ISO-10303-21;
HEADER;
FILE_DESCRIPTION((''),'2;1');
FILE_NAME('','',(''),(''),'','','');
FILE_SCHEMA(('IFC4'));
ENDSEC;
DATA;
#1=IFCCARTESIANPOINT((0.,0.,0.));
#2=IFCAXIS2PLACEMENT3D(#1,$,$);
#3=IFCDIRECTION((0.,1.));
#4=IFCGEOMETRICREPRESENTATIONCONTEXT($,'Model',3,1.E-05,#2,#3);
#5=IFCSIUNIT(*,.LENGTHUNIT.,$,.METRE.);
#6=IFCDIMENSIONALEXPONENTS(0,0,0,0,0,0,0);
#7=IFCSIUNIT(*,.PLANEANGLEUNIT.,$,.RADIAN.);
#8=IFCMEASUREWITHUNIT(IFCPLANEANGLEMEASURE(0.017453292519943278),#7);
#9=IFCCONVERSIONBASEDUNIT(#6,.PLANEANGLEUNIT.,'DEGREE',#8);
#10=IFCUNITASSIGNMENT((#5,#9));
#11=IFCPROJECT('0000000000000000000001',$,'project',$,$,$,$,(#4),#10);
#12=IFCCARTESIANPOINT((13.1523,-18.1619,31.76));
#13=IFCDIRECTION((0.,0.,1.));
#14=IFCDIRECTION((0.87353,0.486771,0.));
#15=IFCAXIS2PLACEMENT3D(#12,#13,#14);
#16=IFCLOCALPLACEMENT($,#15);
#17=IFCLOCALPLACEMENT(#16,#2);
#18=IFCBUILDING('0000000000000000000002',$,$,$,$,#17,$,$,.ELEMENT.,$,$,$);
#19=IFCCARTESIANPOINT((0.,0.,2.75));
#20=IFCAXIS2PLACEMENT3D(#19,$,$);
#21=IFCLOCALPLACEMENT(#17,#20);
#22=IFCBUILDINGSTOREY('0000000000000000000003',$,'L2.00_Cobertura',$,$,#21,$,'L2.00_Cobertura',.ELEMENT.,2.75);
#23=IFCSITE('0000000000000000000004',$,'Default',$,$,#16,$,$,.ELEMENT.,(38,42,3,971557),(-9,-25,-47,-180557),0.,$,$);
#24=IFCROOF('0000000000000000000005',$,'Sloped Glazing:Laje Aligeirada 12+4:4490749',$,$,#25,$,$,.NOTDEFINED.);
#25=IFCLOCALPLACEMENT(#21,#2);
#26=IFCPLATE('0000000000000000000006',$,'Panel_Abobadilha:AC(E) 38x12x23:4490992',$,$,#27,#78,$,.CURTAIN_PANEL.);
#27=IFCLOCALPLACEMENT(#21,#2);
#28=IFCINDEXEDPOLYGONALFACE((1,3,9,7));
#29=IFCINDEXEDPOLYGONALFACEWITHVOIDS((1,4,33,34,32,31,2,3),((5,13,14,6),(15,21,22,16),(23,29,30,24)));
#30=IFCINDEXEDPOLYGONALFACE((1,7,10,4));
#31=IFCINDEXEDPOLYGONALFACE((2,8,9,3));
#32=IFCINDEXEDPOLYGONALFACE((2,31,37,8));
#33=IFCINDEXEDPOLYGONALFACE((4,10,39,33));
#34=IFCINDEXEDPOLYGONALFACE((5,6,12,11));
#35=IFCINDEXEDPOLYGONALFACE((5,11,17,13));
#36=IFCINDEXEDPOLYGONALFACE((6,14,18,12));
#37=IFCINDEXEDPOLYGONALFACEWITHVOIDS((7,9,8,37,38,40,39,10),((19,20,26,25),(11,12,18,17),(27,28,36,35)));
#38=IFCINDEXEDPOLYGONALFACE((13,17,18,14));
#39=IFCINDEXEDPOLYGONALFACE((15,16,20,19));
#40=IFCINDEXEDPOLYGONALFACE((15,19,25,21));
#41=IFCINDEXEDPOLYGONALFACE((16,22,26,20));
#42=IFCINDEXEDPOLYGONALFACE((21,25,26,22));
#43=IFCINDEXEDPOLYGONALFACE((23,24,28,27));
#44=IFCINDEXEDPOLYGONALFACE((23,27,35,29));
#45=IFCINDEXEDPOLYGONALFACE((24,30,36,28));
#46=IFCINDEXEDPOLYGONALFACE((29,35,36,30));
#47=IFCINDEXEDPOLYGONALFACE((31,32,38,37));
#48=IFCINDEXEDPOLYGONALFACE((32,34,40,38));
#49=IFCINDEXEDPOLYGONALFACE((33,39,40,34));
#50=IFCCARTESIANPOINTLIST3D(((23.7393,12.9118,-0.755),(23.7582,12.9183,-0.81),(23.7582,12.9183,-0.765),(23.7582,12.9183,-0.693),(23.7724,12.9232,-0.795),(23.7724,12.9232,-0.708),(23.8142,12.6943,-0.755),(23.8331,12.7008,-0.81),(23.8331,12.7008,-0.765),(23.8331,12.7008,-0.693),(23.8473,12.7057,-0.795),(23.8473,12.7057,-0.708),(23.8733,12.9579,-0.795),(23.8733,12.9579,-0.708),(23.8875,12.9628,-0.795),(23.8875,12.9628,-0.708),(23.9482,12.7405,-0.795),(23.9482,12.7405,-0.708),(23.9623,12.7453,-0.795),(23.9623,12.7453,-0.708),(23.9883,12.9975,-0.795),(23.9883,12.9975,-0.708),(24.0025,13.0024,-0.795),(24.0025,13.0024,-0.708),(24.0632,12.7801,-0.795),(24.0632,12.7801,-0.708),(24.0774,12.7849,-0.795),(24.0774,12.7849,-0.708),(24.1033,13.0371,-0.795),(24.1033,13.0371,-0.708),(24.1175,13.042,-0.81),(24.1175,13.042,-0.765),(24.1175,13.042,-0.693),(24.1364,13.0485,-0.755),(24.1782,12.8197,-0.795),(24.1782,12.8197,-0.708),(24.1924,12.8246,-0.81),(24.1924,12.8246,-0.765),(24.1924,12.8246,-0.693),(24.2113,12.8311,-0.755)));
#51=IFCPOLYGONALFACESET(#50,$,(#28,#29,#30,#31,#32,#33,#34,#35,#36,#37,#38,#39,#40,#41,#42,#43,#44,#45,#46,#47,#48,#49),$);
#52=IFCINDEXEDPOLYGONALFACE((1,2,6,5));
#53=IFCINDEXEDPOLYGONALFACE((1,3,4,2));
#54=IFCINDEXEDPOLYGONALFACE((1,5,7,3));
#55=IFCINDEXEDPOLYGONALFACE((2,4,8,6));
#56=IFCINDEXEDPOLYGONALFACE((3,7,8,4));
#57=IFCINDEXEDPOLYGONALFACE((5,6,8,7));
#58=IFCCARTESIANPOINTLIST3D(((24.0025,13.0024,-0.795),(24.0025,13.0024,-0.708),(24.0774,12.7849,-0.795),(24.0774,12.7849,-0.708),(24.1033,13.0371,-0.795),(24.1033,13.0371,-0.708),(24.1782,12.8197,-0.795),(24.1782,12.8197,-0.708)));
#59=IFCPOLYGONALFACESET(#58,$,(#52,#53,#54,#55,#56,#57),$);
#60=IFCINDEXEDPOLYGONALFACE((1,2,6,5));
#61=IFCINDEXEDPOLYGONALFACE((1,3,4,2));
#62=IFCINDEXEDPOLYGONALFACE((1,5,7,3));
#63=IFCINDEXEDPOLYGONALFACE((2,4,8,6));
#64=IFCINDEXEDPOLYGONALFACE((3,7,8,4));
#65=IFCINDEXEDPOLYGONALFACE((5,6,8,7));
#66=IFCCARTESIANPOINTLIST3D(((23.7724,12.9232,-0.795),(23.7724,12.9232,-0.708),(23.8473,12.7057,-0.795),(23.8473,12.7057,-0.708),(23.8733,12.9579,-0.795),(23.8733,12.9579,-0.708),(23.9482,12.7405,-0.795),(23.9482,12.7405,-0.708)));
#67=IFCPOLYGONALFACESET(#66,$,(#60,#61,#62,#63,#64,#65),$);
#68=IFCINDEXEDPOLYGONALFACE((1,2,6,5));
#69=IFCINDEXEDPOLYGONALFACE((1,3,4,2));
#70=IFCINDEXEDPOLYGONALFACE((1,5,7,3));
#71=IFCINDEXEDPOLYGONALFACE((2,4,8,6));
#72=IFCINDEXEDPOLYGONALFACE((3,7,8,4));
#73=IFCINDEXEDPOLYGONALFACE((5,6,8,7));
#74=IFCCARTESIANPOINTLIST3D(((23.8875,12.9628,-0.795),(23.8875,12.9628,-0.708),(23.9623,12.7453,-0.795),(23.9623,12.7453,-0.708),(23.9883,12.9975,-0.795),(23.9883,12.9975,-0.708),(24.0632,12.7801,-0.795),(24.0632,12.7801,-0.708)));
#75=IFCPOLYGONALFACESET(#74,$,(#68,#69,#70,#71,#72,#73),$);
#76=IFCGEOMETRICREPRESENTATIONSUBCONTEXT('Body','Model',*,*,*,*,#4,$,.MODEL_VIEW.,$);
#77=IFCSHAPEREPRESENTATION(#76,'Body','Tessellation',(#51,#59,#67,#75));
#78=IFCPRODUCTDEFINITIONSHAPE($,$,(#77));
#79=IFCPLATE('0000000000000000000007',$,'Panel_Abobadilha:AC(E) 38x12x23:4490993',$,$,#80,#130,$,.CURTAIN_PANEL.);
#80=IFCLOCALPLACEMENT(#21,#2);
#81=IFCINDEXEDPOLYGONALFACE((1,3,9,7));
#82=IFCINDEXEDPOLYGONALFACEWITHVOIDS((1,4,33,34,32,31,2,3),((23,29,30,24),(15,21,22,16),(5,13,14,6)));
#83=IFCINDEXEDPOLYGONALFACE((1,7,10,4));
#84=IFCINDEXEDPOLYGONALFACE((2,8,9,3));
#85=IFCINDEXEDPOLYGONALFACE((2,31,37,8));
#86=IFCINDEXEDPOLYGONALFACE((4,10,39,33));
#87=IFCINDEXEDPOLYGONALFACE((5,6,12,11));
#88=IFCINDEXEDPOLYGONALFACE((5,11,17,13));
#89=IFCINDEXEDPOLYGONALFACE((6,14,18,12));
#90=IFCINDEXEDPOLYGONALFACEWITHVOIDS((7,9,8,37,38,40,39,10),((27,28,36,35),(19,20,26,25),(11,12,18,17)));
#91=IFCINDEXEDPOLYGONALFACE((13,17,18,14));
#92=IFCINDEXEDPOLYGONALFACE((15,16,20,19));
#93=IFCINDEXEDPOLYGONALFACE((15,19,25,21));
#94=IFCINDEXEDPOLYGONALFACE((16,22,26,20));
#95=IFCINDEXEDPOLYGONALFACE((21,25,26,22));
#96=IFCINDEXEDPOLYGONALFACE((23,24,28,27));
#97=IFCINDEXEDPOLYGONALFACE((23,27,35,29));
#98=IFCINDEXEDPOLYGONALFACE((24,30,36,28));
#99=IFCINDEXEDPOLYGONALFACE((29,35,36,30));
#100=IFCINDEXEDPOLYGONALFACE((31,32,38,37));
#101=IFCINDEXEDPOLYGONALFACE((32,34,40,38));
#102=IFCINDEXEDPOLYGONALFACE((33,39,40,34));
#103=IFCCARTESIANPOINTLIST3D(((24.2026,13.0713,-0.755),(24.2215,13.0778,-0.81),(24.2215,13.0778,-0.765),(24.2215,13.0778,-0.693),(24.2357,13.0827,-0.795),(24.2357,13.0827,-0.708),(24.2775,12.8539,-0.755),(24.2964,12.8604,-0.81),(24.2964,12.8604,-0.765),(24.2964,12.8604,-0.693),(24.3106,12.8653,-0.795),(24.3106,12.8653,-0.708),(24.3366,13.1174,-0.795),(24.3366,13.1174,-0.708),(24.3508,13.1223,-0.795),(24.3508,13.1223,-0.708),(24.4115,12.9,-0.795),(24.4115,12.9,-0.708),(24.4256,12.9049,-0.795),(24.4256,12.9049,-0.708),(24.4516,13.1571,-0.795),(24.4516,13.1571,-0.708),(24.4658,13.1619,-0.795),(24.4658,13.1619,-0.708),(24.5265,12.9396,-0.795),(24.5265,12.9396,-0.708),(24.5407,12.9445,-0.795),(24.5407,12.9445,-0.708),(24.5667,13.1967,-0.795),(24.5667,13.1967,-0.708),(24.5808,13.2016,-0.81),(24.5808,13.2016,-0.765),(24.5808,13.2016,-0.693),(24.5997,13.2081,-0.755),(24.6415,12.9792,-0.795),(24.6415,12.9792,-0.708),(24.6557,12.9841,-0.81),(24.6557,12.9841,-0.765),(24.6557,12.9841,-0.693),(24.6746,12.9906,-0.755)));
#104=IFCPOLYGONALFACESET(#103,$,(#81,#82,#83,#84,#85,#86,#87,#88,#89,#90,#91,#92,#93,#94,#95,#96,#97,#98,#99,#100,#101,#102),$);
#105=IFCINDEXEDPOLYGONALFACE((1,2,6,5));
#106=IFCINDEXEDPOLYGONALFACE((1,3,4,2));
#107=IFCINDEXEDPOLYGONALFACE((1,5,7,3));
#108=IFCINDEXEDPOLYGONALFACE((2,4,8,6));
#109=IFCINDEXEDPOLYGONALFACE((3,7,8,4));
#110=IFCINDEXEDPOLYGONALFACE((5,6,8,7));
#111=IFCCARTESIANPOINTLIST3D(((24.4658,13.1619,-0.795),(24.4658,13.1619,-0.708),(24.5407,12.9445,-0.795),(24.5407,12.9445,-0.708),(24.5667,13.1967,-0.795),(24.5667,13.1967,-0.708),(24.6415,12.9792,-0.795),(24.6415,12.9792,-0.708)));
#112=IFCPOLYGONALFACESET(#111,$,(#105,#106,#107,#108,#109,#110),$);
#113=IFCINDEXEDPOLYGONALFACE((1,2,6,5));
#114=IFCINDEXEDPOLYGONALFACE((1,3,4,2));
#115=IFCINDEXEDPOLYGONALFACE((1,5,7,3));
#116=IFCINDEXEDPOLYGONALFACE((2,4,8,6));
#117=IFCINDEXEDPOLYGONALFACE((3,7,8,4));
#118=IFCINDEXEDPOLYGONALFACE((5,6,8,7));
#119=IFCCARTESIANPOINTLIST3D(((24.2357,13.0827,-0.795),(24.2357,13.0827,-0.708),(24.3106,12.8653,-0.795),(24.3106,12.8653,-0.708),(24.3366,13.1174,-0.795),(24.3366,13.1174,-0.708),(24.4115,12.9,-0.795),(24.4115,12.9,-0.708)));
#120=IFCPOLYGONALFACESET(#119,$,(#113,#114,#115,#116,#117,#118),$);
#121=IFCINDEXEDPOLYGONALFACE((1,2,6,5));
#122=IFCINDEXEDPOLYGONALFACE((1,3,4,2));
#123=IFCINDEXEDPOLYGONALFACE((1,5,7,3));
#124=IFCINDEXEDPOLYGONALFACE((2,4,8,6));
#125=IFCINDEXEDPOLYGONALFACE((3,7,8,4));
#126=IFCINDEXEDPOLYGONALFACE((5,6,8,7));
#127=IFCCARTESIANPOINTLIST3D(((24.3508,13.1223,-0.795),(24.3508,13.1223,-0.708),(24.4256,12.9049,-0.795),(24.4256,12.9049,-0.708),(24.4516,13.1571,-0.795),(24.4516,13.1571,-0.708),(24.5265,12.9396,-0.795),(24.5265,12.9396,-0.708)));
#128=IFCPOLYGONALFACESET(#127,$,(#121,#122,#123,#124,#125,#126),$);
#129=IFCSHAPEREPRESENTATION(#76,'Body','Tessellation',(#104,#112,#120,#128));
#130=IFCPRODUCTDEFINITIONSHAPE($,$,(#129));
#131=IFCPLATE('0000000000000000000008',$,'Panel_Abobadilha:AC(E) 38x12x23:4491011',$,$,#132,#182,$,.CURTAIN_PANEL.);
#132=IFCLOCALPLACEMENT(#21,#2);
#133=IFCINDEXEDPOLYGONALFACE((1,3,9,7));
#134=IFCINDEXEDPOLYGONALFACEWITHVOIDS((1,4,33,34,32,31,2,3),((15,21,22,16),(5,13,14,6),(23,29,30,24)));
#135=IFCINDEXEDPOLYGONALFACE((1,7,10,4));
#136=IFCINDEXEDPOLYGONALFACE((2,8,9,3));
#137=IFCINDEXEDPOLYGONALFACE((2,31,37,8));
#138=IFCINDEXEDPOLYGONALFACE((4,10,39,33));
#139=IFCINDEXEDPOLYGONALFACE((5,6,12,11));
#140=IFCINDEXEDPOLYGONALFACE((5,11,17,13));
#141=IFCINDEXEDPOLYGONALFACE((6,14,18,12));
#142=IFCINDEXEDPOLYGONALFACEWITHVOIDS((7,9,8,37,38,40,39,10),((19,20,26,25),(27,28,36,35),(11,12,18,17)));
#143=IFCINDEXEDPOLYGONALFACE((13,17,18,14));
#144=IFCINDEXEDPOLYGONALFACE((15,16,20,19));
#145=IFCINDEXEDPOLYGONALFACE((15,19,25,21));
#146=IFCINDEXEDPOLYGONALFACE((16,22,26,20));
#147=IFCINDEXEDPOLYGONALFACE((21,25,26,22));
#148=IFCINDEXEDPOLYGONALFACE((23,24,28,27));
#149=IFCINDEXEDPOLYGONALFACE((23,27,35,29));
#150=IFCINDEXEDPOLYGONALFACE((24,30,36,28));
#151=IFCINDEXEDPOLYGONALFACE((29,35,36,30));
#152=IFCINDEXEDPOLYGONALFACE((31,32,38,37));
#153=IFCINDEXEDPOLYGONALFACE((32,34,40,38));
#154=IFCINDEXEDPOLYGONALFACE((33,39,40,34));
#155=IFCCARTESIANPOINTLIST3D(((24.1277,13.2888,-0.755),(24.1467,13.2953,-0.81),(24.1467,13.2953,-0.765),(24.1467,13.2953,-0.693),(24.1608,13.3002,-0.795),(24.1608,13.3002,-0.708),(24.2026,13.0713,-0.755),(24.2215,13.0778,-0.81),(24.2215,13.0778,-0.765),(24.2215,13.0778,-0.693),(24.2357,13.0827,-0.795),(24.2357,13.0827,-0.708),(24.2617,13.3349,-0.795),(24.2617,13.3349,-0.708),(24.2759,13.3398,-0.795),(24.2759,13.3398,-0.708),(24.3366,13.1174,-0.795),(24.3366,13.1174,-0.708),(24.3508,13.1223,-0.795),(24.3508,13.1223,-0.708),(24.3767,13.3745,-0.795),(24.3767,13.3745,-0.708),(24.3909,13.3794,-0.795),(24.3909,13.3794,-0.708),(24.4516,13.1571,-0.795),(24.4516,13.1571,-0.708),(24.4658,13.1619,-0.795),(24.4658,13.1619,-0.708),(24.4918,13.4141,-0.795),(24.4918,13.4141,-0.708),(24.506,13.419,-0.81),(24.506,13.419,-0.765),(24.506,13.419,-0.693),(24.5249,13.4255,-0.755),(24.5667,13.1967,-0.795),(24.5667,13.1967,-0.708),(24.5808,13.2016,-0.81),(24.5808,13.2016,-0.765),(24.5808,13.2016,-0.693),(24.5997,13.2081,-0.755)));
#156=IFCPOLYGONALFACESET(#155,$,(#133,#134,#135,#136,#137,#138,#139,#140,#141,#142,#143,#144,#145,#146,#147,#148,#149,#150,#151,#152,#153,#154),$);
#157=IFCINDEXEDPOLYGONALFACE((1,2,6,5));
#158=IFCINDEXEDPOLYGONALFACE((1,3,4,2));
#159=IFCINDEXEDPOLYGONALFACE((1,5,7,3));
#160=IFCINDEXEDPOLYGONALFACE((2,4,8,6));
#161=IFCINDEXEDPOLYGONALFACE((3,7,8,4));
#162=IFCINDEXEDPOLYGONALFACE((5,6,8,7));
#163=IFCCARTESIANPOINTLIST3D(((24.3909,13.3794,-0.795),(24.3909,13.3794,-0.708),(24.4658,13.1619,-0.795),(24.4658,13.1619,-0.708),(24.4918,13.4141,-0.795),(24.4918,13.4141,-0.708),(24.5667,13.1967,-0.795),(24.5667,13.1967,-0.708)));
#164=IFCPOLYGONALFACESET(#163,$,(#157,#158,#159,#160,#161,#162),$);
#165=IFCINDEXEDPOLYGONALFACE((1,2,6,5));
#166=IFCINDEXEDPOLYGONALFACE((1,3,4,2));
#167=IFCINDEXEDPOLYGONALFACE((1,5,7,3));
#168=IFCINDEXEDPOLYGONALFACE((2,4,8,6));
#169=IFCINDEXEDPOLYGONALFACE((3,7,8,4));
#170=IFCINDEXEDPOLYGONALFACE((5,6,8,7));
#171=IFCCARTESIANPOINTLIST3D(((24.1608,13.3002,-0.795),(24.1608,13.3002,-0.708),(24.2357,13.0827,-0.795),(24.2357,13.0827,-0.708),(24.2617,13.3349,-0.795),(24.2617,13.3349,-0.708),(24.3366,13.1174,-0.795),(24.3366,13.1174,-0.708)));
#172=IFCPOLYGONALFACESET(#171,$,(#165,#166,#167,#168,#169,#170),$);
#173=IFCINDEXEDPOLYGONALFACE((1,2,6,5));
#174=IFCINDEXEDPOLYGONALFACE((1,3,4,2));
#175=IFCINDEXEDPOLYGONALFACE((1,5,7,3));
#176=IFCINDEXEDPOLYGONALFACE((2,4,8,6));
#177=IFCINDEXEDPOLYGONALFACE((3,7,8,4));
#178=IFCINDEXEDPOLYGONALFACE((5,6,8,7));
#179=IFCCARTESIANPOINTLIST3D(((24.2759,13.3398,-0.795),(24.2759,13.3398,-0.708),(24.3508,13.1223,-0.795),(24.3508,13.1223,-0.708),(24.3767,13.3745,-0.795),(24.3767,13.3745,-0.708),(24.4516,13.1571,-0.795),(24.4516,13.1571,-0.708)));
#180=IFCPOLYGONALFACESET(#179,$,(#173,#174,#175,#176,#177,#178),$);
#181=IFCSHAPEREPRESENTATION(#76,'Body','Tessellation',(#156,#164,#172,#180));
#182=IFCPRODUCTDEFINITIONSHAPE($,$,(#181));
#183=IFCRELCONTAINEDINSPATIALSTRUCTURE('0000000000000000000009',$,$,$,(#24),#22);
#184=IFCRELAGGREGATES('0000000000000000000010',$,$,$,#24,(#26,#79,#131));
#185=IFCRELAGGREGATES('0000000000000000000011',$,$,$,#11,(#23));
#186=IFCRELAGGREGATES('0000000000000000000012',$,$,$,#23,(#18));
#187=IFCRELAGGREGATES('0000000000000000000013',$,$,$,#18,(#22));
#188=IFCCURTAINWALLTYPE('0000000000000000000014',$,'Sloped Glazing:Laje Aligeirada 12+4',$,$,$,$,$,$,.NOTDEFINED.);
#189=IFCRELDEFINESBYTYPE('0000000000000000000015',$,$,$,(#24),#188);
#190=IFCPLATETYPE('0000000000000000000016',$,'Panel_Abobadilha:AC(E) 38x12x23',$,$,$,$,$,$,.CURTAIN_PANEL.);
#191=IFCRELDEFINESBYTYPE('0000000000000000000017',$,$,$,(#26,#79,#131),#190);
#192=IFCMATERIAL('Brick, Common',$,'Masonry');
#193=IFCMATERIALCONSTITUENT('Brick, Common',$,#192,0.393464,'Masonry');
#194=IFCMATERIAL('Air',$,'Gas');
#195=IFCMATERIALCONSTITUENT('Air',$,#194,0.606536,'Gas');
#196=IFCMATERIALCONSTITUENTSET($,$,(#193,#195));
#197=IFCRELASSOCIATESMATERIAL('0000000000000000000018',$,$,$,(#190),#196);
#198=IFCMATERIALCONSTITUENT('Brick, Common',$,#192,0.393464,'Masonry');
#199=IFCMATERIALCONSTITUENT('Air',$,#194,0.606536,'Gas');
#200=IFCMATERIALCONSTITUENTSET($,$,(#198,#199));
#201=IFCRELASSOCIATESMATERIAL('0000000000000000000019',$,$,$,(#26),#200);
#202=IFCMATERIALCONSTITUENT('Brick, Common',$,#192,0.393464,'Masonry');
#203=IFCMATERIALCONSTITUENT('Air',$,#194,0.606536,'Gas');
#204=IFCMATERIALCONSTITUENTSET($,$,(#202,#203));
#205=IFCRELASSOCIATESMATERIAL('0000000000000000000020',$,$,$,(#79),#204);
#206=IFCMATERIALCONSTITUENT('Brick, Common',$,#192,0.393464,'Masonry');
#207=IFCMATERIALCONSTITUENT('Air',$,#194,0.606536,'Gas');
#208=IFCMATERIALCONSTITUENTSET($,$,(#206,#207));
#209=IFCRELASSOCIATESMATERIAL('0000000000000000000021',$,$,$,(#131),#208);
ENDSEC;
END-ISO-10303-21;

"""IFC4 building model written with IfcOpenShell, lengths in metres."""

from ifc_helpers import new_model, entity, si_unit, converted_unit, direction, frame, origin, place, context, subcontext, project, spatial, indexed_curve, outline, extrude, source, transform, mapped, material, constituent, constituent_set, type_object, type_shapes, element, aggregate, save


model = new_model("IFC4")

# Units and contexts
model_context = context("Model", 3, precision=1e-05, world=origin(), true_north=direction((0.0, 1.0)))
body_context = subcontext(model_context, "Body", "Model", "MODEL_VIEW")
ifc_project = project(units=[si_unit("LENGTHUNIT", "METRE"), converted_unit("PLANEANGLEUNIT", "DEGREE", entity("IfcPlaneAngleMeasure", 0.017453292519943278), si_unit("PLANEANGLEUNIT", "RADIAN"), dimensions=[0, 0, 0, 0, 0, 0, 0])], contexts=[model_context])

# Site, building, storey
site_placement = place(None, frame((13.1523, -18.1619, 31.76), z_axis=(0.0, 0.0, 1.0), x_axis=(0.87353, 0.486771, 0.0)))
site = spatial("IfcSite", under=ifc_project, at=site_placement, Name="Default", CompositionType="ELEMENT", RefLatitude=(38, 42, 3, 971557), RefLongitude=(-9, -25, -47, -180557), RefElevation=0.0)
building_placement = place(site_placement, origin())
building = spatial("IfcBuilding", under=site, at=building_placement, CompositionType="ELEMENT")
storey_placement = place(building_placement, frame((0.0, 0.0, 2.75)))
storey = spatial("IfcBuildingStorey", under=building, at=storey_placement, Name="L2.00_Cobertura", LongName="L2.00_Cobertura", CompositionType="ELEMENT", Elevation=2.75)

# Roof, plates
curtain_wall_type = type_object("IfcCurtainWallType", Name="Sloped Glazing:Laje Aligeirada 12+4", PredefinedType="NOTDEFINED")
roof_placement = place(storey_placement, frame((0.0, 0.0, -2.75)))
roof = element("IfcRoof", 1, at=roof_placement, inside=storey, type_object=curtain_wall_type, Name="Sloped Glazing:Laje Aligeirada 12+4:4490749", PredefinedType="NOTDEFINED")
ifc_material_1 = material(Name="Brick, Common", Category="Masonry")
ifc_material_2 = material(Name="Air", Category="Gas")
ifc_constituent_1 = constituent(ifc_material_1, Name="Brick, Common", Category="Masonry", fraction=0.393464)
ifc_constituent_2 = constituent(ifc_material_2, Name="Air", Category="Gas", fraction=0.606536)
ifc_constituent_set_1 = constituent_set(constituents=[ifc_constituent_1, ifc_constituent_2])
plate_type = type_object("IfcPlateType", Name="Panel_Abobadilha:AC(E) 38x12x23", PredefinedType="CURTAIN_PANEL", material=ifc_constituent_set_1)
shared_shape_1 = source(origin(), body_context, "Body", "SweptSolid", [
    extrude(outline(indexed_curve([(-0.19, -0.0543), (0.19, -0.0543), (0.19, -0.0093), (0.21, 0.0007), (0.19, 0.0628), (-0.19, 0.0628), (-0.21, 0.0007), (-0.19, -0.0093), (-0.19, -0.0543)], self_intersect=False), holes=[indexed_curve([(-0.0683, 0.0477), (-0.0683, -0.0393), (-0.175, -0.0393), (-0.175, 0.0477), (-0.0683, 0.0477)], self_intersect=False), indexed_curve([(0.0533, 0.0477), (0.0533, -0.0393), (-0.0533, -0.0393), (-0.0533, 0.0477), (0.0533, 0.0477)], self_intersect=False), indexed_curve([(0.175, 0.0477), (0.175, -0.0393), (0.0683, -0.0393), (0.0683, 0.0477), (0.175, 0.0477)], self_intersect=False)]), frame((0.0, 0.0543, 0.0)), (0.0, 0.0, 1.0), 0.23),
    extrude(outline(indexed_curve([(-0.0533, -0.0435), (0.0533, -0.0435), (0.0533, 0.0435), (-0.0533, 0.0435), (-0.0533, -0.0435)], self_intersect=False)), frame((0.1217, 0.0585, 0.0), z_axis=(0.0, 0.0, 1.0), x_axis=(-1.0, 0.0, 0.0)), (0.0, 0.0, 1.0), 0.23),
    extrude(outline(indexed_curve([(-0.0533, -0.0435), (0.0533, -0.0435), (0.0533, 0.0435), (-0.0533, 0.0435), (-0.0533, -0.0435)], self_intersect=False)), frame((-0.1217, 0.0585, 0.0), z_axis=(0.0, 0.0, 1.0), x_axis=(-1.0, 0.0, 0.0)), (0.0, 0.0, 1.0), 0.23),
    extrude(outline(indexed_curve([(-0.0533, -0.0435), (0.0533, -0.0435), (0.0533, 0.0435), (-0.0533, 0.0435), (-0.0533, -0.0435)], self_intersect=False)), frame((0.0, 0.0585, 0.0), z_axis=(0.0, 0.0, 1.0), x_axis=(-1.0, 0.0, 0.0)), (0.0, 0.0, 1.0), 0.23),
])
type_shapes(plate_type, [shared_shape_1])
ifc_constituent_3 = constituent(ifc_material_1, Name="Brick, Common", Category="Masonry", fraction=0.393464)
ifc_constituent_4 = constituent(ifc_material_2, Name="Air", Category="Gas", fraction=0.606536)
ifc_constituent_set_2 = constituent_set(constituents=[ifc_constituent_3, ifc_constituent_4])
plate_1_placement = place(roof_placement, frame((23.9379, 12.9802, 1.94), z_axis=(0.325568, -0.945519, 0.0), x_axis=(0.945519, 0.325568, 0.0)))
plate_1 = element("IfcPlate", 2, at=plate_1_placement, type_object=plate_type, material=ifc_constituent_set_2, Name="Panel_Abobadilha:AC(E) 38x12x23:4490992", PredefinedType="CURTAIN_PANEL", context=body_context, shape_type="MappedRepresentation", body=[
    mapped(shared_shape_1, transform((0.0, 0.0, 0.0), scale=1.0)),
])
ifc_constituent_5 = constituent(ifc_material_1, Name="Brick, Common", Category="Masonry", fraction=0.393464)
ifc_constituent_6 = constituent(ifc_material_2, Name="Air", Category="Gas", fraction=0.606536)
ifc_constituent_set_3 = constituent_set(constituents=[ifc_constituent_5, ifc_constituent_6])
plate_2_placement = place(roof_placement, frame((24.4012, 13.1397, 1.94), z_axis=(0.325568, -0.945519, 0.0), x_axis=(0.945519, 0.325568, 0.0)))
plate_2 = element("IfcPlate", 3, at=plate_2_placement, type_object=plate_type, material=ifc_constituent_set_3, Name="Panel_Abobadilha:AC(E) 38x12x23:4490993", PredefinedType="CURTAIN_PANEL", context=body_context, shape_type="MappedRepresentation", body=[
    mapped(shared_shape_1, transform((0.0, 0.0, 0.0), scale=1.0)),
])
ifc_constituent_7 = constituent(ifc_material_1, Name="Brick, Common", Category="Masonry", fraction=0.393464)
ifc_constituent_8 = constituent(ifc_material_2, Name="Air", Category="Gas", fraction=0.606536)
ifc_constituent_set_4 = constituent_set(constituents=[ifc_constituent_7, ifc_constituent_8])
plate_3_placement = place(roof_placement, frame((24.3263, 13.3572, 1.94), z_axis=(0.325568, -0.945519, 0.0), x_axis=(0.945519, 0.325568, 0.0)))
plate_3 = element("IfcPlate", 4, at=plate_3_placement, type_object=plate_type, material=ifc_constituent_set_4, Name="Panel_Abobadilha:AC(E) 38x12x23:4491011", PredefinedType="CURTAIN_PANEL", context=body_context, shape_type="MappedRepresentation", body=[
    mapped(shared_shape_1, transform((0.0, 0.0, 0.0), scale=1.0)),
])
aggregate(roof, [plate_1, plate_2, plate_3])

save(model, "model.ifc")
